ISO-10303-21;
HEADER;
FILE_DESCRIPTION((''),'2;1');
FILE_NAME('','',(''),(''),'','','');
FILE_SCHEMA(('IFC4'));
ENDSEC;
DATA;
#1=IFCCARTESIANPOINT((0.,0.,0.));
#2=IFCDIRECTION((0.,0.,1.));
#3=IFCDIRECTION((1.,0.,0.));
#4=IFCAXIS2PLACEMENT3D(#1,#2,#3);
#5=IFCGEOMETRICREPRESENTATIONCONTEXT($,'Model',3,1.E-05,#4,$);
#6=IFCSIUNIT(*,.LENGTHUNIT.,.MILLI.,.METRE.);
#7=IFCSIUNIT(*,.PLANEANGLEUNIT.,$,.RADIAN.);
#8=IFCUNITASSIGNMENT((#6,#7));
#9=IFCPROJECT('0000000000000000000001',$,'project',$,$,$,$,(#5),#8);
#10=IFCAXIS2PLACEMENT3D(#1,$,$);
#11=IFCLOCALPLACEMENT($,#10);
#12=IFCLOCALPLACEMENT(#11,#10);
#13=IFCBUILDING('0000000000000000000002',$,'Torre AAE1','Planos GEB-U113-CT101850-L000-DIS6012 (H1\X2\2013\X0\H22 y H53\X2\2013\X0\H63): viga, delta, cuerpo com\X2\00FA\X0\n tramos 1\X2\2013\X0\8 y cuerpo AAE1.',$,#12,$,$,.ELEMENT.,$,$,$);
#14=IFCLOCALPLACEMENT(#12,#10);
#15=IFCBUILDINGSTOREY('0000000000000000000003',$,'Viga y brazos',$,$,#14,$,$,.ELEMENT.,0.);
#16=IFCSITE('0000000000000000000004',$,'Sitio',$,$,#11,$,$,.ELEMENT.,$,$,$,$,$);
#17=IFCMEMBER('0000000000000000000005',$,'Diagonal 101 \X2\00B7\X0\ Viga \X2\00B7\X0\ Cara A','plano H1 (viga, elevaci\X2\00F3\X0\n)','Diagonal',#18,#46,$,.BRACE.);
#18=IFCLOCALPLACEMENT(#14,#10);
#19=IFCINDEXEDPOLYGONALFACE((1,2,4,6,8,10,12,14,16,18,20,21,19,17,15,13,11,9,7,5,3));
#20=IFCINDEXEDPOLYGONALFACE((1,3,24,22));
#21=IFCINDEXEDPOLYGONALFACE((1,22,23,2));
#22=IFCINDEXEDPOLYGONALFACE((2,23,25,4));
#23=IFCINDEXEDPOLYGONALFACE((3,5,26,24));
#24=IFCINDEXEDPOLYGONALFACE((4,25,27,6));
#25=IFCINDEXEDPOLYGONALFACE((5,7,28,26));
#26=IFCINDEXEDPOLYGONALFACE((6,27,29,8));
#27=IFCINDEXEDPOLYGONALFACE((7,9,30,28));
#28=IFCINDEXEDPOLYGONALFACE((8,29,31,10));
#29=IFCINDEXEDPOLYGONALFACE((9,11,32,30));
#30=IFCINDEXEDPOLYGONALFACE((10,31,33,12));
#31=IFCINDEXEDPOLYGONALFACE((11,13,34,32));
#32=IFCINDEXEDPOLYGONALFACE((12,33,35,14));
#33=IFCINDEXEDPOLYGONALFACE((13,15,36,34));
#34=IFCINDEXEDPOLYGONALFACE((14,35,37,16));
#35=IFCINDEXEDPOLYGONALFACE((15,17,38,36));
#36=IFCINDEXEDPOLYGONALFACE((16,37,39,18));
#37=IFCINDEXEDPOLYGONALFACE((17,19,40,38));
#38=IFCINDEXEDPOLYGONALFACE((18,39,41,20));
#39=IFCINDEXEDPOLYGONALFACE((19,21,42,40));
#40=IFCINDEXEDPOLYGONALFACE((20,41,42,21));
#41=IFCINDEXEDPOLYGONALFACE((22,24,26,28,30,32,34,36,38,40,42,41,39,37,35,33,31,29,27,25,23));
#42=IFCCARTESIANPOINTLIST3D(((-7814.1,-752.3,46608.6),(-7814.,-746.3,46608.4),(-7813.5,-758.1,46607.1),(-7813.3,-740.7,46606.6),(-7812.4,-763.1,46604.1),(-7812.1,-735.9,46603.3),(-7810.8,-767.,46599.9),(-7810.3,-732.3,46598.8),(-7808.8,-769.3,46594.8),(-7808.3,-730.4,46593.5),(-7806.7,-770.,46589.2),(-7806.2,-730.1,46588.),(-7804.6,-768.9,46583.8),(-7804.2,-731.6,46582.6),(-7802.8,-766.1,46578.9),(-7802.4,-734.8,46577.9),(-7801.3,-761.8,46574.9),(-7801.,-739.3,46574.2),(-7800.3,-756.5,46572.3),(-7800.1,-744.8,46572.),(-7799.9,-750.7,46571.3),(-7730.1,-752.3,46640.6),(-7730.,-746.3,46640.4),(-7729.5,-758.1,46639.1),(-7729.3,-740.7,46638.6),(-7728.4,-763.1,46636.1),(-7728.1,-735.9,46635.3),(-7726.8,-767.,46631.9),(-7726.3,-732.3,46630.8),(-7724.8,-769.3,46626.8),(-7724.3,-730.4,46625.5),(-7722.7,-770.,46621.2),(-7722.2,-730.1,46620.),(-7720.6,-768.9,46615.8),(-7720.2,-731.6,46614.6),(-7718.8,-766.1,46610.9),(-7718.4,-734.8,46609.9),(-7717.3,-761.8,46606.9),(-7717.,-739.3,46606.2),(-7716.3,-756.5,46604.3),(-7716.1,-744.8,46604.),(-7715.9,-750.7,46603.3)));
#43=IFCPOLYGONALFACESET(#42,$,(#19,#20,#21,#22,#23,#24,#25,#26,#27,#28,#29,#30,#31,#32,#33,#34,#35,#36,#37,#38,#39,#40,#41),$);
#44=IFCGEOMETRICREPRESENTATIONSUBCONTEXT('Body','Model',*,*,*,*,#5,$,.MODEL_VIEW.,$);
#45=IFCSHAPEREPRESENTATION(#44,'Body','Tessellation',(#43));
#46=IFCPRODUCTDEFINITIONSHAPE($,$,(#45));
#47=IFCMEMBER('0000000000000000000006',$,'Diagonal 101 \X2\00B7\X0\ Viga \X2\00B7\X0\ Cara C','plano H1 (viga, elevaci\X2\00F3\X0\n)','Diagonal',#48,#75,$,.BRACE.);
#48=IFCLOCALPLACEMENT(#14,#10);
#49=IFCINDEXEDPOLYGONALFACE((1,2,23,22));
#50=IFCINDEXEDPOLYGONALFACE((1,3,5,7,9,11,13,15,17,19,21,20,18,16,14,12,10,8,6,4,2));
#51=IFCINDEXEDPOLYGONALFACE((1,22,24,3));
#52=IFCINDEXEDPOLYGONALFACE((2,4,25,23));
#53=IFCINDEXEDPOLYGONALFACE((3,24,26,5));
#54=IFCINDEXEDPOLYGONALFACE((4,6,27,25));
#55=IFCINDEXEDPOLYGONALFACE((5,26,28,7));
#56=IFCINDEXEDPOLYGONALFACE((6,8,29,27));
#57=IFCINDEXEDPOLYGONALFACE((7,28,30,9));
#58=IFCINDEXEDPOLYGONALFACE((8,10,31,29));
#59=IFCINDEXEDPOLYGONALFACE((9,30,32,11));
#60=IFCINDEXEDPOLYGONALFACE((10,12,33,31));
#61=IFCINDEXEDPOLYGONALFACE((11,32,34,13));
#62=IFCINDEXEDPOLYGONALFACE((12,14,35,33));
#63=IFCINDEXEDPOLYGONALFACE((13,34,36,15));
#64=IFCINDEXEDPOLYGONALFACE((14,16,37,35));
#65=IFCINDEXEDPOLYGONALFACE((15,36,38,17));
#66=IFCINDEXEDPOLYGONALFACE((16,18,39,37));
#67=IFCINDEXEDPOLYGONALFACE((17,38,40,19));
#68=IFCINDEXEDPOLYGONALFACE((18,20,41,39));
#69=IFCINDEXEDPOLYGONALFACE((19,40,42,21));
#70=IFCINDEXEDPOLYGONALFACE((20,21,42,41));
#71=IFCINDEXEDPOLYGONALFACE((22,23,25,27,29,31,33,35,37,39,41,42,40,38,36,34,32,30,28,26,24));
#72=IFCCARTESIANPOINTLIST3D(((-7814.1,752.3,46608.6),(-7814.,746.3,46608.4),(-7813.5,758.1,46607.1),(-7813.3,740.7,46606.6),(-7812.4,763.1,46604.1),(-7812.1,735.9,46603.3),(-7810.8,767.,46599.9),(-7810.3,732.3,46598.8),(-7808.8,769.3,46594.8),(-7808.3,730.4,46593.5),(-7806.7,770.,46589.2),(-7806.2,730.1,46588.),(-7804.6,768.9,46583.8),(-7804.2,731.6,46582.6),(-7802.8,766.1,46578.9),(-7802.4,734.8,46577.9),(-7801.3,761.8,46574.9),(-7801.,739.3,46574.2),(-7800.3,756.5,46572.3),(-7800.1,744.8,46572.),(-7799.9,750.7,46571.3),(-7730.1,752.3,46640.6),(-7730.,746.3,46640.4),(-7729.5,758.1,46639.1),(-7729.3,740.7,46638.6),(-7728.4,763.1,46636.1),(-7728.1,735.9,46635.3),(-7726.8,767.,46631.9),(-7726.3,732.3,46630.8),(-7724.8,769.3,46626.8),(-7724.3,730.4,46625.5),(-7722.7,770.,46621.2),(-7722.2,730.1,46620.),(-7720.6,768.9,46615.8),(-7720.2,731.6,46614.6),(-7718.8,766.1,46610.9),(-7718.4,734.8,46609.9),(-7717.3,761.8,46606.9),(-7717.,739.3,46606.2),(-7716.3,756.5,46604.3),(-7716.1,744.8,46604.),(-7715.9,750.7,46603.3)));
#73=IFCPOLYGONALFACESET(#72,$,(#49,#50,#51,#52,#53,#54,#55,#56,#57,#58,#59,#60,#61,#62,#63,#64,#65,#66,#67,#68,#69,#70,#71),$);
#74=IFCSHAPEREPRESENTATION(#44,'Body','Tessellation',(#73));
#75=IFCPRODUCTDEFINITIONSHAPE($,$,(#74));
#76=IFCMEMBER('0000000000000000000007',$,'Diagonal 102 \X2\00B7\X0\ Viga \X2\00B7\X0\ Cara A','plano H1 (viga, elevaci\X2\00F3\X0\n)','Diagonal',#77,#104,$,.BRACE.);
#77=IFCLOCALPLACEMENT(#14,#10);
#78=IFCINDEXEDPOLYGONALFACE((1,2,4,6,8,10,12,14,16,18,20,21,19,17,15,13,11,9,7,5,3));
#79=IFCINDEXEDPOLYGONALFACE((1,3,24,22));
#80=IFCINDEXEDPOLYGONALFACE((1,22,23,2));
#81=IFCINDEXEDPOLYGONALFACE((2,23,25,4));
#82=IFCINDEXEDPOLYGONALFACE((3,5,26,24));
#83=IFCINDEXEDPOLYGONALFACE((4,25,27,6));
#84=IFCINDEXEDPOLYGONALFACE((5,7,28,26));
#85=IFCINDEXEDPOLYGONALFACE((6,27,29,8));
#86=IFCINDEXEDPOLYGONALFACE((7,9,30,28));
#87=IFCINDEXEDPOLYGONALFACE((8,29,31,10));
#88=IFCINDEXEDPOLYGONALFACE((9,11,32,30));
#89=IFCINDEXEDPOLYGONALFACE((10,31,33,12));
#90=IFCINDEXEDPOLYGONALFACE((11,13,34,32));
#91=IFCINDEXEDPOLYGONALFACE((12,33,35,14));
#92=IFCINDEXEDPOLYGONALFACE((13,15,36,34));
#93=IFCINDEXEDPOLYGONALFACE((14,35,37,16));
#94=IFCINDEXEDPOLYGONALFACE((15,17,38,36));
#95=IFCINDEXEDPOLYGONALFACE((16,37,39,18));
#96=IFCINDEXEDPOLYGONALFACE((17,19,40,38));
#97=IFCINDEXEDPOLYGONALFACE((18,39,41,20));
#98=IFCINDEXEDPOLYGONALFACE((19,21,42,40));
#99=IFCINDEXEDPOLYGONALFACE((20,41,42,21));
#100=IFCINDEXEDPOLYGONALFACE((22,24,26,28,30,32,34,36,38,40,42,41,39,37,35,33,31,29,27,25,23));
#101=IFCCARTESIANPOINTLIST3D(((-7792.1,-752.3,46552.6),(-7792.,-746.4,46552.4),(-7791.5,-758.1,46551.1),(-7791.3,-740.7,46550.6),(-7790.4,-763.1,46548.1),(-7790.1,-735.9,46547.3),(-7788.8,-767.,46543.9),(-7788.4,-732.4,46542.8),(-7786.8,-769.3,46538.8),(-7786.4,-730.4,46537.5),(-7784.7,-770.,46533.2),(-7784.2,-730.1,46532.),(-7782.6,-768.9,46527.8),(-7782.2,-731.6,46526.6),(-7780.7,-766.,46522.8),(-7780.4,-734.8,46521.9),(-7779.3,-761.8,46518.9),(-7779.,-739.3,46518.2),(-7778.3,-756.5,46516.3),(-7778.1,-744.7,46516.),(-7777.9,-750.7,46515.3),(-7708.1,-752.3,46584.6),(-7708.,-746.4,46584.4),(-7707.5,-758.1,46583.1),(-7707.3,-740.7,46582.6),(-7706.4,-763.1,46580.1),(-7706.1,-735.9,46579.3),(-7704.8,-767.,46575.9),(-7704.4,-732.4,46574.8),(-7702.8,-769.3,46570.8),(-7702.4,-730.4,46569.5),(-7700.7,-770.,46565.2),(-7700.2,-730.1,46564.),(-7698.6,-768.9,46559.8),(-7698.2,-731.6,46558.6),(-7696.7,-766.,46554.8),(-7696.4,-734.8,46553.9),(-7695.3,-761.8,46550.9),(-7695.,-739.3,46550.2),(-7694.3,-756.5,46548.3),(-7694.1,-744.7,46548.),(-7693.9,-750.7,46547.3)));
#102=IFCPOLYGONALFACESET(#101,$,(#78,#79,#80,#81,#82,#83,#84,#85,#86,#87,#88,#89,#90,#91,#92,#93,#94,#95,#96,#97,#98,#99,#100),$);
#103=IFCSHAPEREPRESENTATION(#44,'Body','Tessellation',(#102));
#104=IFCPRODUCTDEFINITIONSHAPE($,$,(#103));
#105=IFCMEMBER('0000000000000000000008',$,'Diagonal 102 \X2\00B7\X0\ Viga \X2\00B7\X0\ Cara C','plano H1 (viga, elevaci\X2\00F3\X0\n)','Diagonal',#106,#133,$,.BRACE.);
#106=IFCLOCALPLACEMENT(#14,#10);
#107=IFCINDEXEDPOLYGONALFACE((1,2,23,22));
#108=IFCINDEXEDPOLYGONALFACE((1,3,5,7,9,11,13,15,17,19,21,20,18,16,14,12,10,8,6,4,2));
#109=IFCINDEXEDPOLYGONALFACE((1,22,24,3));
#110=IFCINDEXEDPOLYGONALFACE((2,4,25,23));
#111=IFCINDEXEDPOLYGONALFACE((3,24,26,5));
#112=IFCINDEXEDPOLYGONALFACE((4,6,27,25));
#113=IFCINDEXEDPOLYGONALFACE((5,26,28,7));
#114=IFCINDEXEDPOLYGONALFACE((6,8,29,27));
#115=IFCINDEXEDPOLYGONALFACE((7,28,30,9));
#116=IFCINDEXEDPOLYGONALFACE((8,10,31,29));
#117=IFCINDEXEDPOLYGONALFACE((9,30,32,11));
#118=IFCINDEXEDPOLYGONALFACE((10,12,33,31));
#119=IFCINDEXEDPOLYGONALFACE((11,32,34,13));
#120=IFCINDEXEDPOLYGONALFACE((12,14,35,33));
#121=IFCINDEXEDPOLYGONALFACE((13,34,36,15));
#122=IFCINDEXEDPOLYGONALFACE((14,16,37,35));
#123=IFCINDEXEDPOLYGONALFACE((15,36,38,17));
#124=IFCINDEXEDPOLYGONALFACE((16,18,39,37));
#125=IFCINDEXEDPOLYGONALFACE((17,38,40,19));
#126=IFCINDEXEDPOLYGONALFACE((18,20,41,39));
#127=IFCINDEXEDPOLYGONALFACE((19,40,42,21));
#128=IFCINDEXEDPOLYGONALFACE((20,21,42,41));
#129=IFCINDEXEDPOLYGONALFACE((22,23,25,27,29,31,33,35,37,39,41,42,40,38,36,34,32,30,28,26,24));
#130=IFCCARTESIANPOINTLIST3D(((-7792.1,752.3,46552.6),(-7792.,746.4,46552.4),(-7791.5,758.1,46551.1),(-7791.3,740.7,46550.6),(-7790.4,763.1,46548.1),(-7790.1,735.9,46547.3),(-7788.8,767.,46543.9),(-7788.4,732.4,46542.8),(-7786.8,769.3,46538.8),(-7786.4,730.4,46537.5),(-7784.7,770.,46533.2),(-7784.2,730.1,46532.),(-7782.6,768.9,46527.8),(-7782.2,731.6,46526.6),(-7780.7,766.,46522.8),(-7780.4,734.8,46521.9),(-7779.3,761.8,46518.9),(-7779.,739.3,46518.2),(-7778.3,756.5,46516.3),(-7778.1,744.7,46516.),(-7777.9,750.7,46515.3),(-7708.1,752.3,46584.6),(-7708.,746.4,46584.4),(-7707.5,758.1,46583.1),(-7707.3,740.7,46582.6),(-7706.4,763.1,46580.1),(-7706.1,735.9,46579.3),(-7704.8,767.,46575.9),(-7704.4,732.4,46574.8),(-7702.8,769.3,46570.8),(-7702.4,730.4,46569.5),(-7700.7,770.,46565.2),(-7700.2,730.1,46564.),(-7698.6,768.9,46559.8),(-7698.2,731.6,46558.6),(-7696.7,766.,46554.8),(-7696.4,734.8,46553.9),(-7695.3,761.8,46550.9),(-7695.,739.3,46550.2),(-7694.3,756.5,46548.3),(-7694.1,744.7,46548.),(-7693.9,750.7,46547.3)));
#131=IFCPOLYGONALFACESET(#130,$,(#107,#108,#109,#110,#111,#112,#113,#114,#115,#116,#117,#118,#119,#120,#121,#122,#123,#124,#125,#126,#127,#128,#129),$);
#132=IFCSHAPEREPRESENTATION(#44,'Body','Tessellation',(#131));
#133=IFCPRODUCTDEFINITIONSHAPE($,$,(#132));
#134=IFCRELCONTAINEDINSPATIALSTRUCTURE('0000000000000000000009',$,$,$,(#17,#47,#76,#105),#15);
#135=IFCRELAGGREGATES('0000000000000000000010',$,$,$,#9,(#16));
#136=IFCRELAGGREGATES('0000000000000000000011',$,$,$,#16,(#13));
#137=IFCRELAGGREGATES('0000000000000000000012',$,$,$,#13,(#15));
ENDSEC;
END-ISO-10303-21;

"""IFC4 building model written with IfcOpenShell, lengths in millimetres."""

from ifc_helpers import new_model, si_unit, frame, origin, origin_with_axes, place, context, subcontext, project, spatial, circle, extrude, element, save


model = new_model("IFC4")

# Units and contexts
model_context = context("Model", 3, precision=1e-05, world=origin_with_axes())
body_context = subcontext(model_context, "Body", "Model", "MODEL_VIEW")
ifc_project = project(units=[si_unit("LENGTHUNIT", "METRE", prefix="MILLI"), si_unit("PLANEANGLEUNIT", "RADIAN")], contexts=[model_context])

# Site, building, storey
site_placement = place(None, origin())
site = spatial("IfcSite", under=ifc_project, at=site_placement, Name="Sitio", CompositionType="ELEMENT")
building_placement = place(site_placement, origin())
building = spatial("IfcBuilding", under=site, at=building_placement, Name="Torre AAE1", Description="Planos GEB-U113-CT101850-L000-DIS6012 (H1–H22 y H53–H63): viga, delta, cuerpo común tramos 1–8 y cuerpo AAE1.", CompositionType="ELEMENT")
storey_placement = place(building_placement, origin())
storey = spatial("IfcBuildingStorey", under=building, at=storey_placement, Name="Viga y brazos", CompositionType="ELEMENT", Elevation=0.0)

# Members
for number, where, z_axis, x_axis, name in (
    (1, (-7723.0, -750.0, 46622.0), (-0.934488, 0.0, -0.355995), (0.343574, 0.261849, -0.901882), "Diagonal 101 · Viga · Cara A"),
    (2, (-7723.0, 750.0, 46622.0), (-0.934488, 0.0, -0.355995), (0.343574, -0.261849, -0.901882), "Diagonal 101 · Viga · Cara C"),
    (3, (-7701.0, -750.0, 46566.0), (-0.934488, 0.0, -0.355995), (0.343507, 0.262542, -0.901706), "Diagonal 102 · Viga · Cara A"),
    (4, (-7701.0, 750.0, 46566.0), (-0.934488, 0.0, -0.355995), (0.343507, -0.262542, -0.901706), "Diagonal 102 · Viga · Cara C"),
):
    element("IfcMember", number, at=place(storey_placement, frame(where, z_axis=z_axis, x_axis=x_axis)), inside=storey, Name=name, Description="plano H1 (viga, elevación)", ObjectType="Diagonal", PredefinedType="BRACE", context=body_context, shape_type="SweptSolid", body=[
        extrude(circle(Radius=20.0), None, (0.0, 0.0, 1.0), 89.9),
    ])

save(model, "model.ifc")
